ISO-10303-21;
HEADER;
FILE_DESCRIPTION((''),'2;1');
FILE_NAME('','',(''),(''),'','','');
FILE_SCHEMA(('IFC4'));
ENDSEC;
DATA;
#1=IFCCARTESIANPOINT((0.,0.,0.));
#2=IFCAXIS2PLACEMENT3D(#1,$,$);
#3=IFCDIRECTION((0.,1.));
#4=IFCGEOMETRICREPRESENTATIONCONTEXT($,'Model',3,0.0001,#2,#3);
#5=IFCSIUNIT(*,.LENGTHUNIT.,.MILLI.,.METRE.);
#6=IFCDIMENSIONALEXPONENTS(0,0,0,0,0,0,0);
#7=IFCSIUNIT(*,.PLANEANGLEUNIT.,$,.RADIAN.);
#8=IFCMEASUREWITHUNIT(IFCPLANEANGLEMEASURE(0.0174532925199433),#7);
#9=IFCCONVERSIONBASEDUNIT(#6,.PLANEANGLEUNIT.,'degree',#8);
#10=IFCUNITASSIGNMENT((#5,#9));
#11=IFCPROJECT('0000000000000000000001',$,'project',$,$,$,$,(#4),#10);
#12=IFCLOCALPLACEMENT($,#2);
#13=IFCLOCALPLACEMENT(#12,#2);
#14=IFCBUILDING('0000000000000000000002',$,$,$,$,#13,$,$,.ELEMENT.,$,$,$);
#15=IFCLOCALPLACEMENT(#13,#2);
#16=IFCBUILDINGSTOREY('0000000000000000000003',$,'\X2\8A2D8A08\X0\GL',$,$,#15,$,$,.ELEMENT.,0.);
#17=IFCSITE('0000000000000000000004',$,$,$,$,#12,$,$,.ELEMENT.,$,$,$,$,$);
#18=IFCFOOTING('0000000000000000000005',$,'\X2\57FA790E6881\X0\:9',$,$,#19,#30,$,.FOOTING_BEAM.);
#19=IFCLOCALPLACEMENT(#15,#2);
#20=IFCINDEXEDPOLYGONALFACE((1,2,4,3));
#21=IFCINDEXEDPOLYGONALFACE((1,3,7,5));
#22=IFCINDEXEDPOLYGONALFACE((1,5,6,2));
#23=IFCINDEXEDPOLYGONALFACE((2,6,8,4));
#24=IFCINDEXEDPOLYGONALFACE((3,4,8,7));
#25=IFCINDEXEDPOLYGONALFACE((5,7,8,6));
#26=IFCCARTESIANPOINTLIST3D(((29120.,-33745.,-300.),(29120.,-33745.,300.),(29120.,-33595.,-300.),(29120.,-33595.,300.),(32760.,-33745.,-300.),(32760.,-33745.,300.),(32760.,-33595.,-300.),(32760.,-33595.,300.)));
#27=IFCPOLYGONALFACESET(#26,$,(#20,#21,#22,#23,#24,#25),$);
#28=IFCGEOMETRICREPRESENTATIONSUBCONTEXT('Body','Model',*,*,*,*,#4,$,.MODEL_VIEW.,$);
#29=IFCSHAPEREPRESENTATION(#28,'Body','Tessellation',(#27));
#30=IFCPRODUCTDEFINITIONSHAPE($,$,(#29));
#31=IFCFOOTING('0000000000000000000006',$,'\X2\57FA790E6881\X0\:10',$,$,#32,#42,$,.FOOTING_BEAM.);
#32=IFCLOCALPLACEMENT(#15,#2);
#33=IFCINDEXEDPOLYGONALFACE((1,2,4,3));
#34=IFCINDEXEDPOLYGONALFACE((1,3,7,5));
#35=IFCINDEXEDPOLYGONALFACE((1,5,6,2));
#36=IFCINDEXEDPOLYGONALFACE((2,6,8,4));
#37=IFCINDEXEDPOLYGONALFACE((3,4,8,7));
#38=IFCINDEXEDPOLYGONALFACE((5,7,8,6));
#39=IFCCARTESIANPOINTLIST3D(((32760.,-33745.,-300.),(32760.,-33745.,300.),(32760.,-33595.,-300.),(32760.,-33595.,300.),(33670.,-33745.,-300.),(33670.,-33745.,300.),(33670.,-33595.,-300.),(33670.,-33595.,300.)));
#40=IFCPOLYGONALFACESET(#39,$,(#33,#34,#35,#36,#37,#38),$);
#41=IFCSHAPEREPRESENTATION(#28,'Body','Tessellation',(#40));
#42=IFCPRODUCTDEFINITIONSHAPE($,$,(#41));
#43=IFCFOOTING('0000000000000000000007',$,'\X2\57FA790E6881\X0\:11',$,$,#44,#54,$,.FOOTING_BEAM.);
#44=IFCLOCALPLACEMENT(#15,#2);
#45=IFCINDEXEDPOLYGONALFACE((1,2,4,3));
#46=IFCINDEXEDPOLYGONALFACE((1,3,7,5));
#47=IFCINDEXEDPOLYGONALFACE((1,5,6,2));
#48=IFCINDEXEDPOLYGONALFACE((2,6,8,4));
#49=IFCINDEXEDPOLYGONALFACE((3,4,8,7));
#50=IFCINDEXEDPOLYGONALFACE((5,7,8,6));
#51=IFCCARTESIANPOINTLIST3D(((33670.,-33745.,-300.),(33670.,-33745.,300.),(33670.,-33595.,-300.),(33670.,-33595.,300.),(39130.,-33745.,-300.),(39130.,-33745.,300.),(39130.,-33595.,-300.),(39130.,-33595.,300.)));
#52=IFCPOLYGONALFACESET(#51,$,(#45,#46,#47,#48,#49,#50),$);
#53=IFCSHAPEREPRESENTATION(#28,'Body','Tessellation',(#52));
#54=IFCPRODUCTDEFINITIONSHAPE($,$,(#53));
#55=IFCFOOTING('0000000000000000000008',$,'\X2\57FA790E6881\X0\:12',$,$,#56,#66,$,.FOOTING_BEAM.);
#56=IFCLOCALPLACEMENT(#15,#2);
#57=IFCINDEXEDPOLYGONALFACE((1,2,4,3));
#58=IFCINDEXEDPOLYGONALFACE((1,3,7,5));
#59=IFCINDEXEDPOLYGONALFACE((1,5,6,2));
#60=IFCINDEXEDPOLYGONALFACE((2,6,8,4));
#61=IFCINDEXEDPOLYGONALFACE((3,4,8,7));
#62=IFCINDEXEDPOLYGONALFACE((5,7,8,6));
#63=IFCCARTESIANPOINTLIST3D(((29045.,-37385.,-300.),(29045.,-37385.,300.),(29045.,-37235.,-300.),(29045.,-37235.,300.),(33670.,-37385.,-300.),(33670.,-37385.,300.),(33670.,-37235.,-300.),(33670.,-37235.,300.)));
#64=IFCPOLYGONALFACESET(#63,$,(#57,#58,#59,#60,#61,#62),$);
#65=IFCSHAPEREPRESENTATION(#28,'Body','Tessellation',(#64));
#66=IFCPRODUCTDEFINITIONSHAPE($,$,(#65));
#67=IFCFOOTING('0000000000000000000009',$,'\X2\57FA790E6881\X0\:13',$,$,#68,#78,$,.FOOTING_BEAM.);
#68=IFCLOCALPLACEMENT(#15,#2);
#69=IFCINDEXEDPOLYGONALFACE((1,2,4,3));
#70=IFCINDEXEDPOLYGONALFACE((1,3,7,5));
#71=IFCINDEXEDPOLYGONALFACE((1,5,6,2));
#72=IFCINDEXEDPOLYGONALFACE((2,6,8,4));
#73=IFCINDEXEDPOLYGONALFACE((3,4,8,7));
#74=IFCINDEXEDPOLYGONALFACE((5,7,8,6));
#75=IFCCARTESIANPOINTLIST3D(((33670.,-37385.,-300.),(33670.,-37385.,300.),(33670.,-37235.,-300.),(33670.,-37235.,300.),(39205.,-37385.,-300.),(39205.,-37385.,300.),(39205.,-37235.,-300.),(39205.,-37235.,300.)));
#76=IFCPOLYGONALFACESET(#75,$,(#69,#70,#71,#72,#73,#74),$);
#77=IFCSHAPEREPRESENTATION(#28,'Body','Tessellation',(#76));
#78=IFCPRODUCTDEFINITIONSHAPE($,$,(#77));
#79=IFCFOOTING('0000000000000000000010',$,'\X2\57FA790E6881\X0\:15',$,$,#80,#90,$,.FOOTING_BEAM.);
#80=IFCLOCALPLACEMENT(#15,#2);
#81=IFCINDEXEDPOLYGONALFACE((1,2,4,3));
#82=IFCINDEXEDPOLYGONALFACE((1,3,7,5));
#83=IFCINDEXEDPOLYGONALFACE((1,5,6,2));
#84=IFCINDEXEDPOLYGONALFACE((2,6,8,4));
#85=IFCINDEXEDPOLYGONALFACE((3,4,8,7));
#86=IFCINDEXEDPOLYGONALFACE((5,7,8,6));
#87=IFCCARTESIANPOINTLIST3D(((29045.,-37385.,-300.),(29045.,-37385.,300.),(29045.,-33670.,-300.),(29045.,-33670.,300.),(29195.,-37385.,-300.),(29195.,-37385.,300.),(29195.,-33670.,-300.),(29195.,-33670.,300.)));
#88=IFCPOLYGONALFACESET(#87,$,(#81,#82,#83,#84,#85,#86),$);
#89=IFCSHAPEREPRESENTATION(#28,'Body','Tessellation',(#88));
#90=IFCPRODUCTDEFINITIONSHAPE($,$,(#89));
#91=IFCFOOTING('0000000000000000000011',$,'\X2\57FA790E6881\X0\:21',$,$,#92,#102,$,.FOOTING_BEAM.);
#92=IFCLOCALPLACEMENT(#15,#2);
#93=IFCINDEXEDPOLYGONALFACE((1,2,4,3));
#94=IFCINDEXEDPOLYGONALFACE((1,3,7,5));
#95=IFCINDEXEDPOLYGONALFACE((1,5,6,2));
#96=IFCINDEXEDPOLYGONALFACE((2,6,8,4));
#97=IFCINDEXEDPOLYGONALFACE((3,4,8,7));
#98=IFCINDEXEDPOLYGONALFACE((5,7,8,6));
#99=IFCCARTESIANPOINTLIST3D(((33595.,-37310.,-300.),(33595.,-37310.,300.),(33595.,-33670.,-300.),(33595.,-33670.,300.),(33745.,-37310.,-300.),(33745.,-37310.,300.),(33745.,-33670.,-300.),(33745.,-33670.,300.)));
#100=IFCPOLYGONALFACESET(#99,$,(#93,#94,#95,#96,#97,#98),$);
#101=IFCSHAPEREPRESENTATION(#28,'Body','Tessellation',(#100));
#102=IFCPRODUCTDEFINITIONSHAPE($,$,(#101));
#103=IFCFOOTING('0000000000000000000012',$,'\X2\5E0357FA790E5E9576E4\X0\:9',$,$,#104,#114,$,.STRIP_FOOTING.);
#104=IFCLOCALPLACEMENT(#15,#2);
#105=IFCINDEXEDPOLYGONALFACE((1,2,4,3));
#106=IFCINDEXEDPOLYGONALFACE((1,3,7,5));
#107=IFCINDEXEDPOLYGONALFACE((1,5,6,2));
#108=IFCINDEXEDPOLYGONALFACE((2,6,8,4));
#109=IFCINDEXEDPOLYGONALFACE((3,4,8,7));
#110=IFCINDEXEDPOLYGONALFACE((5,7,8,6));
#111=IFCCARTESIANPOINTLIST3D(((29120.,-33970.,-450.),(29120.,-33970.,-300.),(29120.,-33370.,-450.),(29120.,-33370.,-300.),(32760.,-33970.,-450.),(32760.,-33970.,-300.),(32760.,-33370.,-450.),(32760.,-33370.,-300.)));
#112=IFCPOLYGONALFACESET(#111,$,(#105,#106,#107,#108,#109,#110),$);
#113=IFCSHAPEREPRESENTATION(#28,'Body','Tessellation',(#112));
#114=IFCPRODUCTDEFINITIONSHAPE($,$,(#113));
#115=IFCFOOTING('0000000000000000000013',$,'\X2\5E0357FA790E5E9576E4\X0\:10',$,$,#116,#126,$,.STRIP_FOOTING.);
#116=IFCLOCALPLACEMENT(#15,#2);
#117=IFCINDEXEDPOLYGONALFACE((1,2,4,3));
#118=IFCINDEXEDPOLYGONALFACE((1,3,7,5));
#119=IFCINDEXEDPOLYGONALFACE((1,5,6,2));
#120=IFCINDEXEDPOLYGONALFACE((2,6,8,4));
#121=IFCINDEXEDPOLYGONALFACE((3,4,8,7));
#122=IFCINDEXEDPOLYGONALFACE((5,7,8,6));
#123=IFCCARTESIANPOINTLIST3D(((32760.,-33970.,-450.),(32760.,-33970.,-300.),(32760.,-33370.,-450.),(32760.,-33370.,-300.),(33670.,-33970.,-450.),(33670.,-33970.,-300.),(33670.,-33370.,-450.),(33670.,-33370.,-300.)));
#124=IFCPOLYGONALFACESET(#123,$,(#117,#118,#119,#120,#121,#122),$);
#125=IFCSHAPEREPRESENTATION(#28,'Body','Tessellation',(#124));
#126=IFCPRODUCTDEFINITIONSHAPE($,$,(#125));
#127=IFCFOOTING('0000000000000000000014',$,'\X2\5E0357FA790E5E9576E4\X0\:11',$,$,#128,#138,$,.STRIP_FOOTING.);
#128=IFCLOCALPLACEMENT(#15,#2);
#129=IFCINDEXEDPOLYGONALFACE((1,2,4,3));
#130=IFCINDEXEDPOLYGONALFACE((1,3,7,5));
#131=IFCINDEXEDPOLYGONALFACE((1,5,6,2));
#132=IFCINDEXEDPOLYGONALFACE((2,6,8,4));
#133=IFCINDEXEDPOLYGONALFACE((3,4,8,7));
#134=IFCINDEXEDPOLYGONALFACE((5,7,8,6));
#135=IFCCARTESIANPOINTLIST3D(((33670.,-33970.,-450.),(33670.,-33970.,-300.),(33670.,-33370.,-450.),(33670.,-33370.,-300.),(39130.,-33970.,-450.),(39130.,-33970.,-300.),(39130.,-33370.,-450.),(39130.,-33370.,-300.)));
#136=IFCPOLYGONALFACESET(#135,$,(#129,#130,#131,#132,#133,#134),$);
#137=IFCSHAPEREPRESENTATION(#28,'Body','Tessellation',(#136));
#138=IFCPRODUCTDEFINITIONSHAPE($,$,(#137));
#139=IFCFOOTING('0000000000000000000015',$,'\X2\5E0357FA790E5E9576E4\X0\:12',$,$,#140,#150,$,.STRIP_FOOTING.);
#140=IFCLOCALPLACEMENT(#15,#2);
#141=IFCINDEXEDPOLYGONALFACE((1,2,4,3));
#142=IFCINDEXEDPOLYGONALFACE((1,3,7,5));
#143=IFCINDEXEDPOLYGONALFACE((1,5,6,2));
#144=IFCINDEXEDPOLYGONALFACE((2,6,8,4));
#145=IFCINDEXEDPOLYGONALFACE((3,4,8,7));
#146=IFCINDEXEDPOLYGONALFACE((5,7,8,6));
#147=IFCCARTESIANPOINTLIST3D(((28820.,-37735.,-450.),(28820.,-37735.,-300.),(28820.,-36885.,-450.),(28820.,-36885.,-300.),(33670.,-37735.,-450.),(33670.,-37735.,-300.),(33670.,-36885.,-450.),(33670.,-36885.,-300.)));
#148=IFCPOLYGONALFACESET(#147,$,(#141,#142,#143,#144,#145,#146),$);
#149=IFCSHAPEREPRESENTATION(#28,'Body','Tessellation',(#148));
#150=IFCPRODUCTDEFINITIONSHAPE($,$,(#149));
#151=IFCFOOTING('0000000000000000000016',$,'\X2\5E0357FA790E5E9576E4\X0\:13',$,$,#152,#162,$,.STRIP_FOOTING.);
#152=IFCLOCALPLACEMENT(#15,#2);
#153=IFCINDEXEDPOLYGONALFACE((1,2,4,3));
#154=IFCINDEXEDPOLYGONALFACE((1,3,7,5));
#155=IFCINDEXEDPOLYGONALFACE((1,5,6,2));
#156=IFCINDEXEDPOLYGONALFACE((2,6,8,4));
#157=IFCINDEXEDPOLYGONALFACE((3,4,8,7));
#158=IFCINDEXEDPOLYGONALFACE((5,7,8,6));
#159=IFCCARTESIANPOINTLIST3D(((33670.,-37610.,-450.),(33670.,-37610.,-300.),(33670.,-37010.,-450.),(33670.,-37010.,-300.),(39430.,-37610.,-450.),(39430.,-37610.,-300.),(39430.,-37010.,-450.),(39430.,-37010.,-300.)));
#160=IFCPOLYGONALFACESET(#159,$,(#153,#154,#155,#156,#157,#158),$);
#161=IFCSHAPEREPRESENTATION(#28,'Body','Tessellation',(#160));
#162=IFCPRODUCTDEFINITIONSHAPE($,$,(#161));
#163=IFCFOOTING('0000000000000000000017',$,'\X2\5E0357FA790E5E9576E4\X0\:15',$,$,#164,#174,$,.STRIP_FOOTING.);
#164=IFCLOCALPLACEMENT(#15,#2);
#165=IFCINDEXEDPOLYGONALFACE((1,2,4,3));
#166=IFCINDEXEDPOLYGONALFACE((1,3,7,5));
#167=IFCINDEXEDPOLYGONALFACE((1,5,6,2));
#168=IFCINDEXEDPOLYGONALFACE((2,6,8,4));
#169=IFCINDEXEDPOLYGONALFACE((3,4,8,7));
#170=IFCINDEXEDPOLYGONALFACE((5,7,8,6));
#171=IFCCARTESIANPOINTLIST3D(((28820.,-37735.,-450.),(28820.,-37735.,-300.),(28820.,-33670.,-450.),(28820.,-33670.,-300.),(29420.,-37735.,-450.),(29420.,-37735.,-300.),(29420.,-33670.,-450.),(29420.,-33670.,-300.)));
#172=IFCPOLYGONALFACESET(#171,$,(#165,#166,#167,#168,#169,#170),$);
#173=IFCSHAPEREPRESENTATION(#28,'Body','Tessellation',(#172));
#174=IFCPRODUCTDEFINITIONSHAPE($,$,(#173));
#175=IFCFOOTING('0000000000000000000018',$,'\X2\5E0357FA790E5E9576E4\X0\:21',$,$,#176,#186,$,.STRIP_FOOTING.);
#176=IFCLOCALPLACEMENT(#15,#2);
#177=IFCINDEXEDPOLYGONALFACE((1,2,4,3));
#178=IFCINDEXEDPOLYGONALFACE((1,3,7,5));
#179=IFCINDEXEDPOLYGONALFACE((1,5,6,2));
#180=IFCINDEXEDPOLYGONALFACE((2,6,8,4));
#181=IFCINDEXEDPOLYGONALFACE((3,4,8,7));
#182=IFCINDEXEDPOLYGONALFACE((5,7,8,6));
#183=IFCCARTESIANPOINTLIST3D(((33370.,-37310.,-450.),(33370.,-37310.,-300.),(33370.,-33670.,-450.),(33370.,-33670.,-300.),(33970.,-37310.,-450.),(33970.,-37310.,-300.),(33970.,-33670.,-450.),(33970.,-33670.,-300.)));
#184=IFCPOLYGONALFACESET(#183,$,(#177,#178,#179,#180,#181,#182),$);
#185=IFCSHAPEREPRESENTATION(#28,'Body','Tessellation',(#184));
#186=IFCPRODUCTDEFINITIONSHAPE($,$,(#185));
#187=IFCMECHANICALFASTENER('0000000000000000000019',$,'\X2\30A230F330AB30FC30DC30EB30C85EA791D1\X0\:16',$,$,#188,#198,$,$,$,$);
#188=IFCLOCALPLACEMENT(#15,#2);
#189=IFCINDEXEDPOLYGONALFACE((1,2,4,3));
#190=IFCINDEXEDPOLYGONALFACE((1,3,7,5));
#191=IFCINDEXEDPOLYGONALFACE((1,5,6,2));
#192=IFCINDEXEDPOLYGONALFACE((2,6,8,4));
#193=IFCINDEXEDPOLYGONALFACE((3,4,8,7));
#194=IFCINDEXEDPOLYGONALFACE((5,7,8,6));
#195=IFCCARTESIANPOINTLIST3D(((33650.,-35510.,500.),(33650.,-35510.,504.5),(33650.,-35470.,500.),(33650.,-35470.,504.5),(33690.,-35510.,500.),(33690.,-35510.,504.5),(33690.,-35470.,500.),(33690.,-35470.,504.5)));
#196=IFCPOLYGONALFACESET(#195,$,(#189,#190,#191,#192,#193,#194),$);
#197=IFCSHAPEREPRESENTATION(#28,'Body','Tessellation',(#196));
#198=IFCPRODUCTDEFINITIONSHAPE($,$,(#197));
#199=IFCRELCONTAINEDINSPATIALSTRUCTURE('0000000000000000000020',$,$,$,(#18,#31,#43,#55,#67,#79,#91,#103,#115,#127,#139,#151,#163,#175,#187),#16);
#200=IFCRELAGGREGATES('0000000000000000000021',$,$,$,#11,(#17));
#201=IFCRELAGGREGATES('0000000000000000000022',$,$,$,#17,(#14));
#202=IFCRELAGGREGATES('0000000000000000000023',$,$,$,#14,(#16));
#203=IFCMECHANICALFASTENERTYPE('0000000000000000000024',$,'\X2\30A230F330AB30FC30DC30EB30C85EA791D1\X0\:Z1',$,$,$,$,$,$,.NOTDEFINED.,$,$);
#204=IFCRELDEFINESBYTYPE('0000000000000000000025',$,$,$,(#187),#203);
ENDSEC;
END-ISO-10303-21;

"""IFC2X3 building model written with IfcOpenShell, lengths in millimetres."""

from ifc_helpers import new_model, entity, si_unit, converted_unit, direction, frame, origin, origin_with_axes, origin_2d, place, context, subcontext, project, spatial, rectangle, extrude, type_object, element, save


model = new_model("IFC2X3")

# Units and contexts
model_context = context("Model", 3, precision=0.0001, world=origin(), true_north=direction((0.0, 1.0)))
body_context = subcontext(model_context, "Body", "Model", "MODEL_VIEW")
ifc_project = project(units=[si_unit("LENGTHUNIT", "METRE", prefix="MILLI"), converted_unit("PLANEANGLEUNIT", "degree", entity("IfcPlaneAngleMeasure", 0.0174532925199433), si_unit("PLANEANGLEUNIT", "RADIAN"), dimensions=[0, 0, 0, 0, 0, 0, 0])], contexts=[model_context])

# Site, building, storey
site_placement = place(None, origin())
site = spatial("IfcSite", under=ifc_project, at=site_placement, CompositionType="ELEMENT")
building_placement = place(site_placement, origin())
building = spatial("IfcBuilding", under=site, at=building_placement, CompositionType="ELEMENT")
storey_placement = place(building_placement, origin())
storey = spatial("IfcBuildingStorey", under=building, at=storey_placement, Name="設計GL", CompositionType="ELEMENT", Elevation=0.0)

# Footings
footing_1_placement = place(storey_placement, frame((29120.0, -33670.0, 0.0), z_axis=(1.0, 0.0, 0.0), x_axis=(0.0, 1.0, 0.0)))
element("IfcFooting", 1, at=footing_1_placement, inside=storey, Name="基礎梁:9", PredefinedType="FOOTING_BEAM", context=body_context, shape_type="SolidModel", body=[
    extrude(rectangle(XDim=150.0, YDim=600.0, at=origin_2d()), origin_with_axes(), (0.0, 0.0, 1.0), 3640.0),
])
footing_2_placement = place(storey_placement, frame((32760.0, -33670.0, 0.0), z_axis=(1.0, 0.0, 0.0), x_axis=(0.0, 1.0, 0.0)))
element("IfcFooting", 2, at=footing_2_placement, inside=storey, Name="基礎梁:10", PredefinedType="FOOTING_BEAM", context=body_context, shape_type="SolidModel", body=[
    extrude(rectangle(XDim=150.0, YDim=600.0, at=origin_2d()), origin_with_axes(), (0.0, 0.0, 1.0), 910.0),
])
footing_3_placement = place(storey_placement, frame((33670.0, -33670.0, 0.0), z_axis=(1.0, 0.0, 0.0), x_axis=(0.0, 1.0, 0.0)))
element("IfcFooting", 3, at=footing_3_placement, inside=storey, Name="基礎梁:11", PredefinedType="FOOTING_BEAM", context=body_context, shape_type="SolidModel", body=[
    extrude(rectangle(XDim=150.0, YDim=600.0, at=origin_2d()), origin_with_axes(), (0.0, 0.0, 1.0), 5460.0),
])
footing_4_placement = place(storey_placement, frame((29045.0, -37310.0, 0.0), z_axis=(1.0, 0.0, 0.0), x_axis=(0.0, 1.0, 0.0)))
element("IfcFooting", 4, at=footing_4_placement, inside=storey, Name="基礎梁:12", PredefinedType="FOOTING_BEAM", context=body_context, shape_type="SolidModel", body=[
    extrude(rectangle(XDim=150.0, YDim=600.0, at=origin_2d()), origin_with_axes(), (0.0, 0.0, 1.0), 4625.0),
])
footing_5_placement = place(storey_placement, frame((33670.0, -37310.0, 0.0), z_axis=(1.0, 0.0, 0.0), x_axis=(0.0, 1.0, 0.0)))
element("IfcFooting", 5, at=footing_5_placement, inside=storey, Name="基礎梁:13", PredefinedType="FOOTING_BEAM", context=body_context, shape_type="SolidModel", body=[
    extrude(rectangle(XDim=150.0, YDim=600.0, at=origin_2d()), origin_with_axes(), (0.0, 0.0, 1.0), 5535.0),
])
footing_6_placement = place(storey_placement, frame((29120.0, -33670.0, 0.0), z_axis=(0.0, -1.0, 0.0), x_axis=(1.0, 0.0, 0.0)))
element("IfcFooting", 6, at=footing_6_placement, inside=storey, Name="基礎梁:15", PredefinedType="FOOTING_BEAM", context=body_context, shape_type="SolidModel", body=[
    extrude(rectangle(XDim=150.0, YDim=600.0, at=origin_2d()), origin_with_axes(), (0.0, 0.0, 1.0), 3715.0),
])
footing_7_placement = place(storey_placement, frame((33670.0, -33670.0, 0.0), z_axis=(0.0, -1.0, 0.0), x_axis=(1.0, 0.0, 0.0)))
element("IfcFooting", 7, at=footing_7_placement, inside=storey, Name="基礎梁:21", PredefinedType="FOOTING_BEAM", context=body_context, shape_type="SolidModel", body=[
    extrude(rectangle(XDim=150.0, YDim=600.0, at=origin_2d()), origin_with_axes(), (0.0, 0.0, 1.0), 3640.0),
])
footing_8_placement = place(storey_placement, frame((29120.0, -33670.0, -375.0), z_axis=(1.0, 0.0, 0.0), x_axis=(0.0, -1.0, 0.0)))
element("IfcFooting", 8, at=footing_8_placement, inside=storey, Name="布基礎底盤:9", PredefinedType="STRIP_FOOTING", context=body_context, shape_type="SweptSolid", body=[
    extrude(rectangle(XDim=600.0, YDim=150.0, at=origin_2d()), origin_with_axes(), (0.0, 0.0, 1.0), 3640.0),
])
footing_9_placement = place(storey_placement, frame((32760.0, -33670.0, -375.0), z_axis=(1.0, 0.0, 0.0), x_axis=(0.0, -1.0, 0.0)))
element("IfcFooting", 9, at=footing_9_placement, inside=storey, Name="布基礎底盤:10", PredefinedType="STRIP_FOOTING", context=body_context, shape_type="SweptSolid", body=[
    extrude(rectangle(XDim=600.0, YDim=150.0, at=origin_2d()), origin_with_axes(), (0.0, 0.0, 1.0), 910.0),
])
footing_10_placement = place(storey_placement, frame((33670.0, -33670.0, -375.0), z_axis=(1.0, 0.0, 0.0), x_axis=(0.0, -1.0, 0.0)))
element("IfcFooting", 10, at=footing_10_placement, inside=storey, Name="布基礎底盤:11", PredefinedType="STRIP_FOOTING", context=body_context, shape_type="SweptSolid", body=[
    extrude(rectangle(XDim=600.0, YDim=150.0, at=origin_2d()), origin_with_axes(), (0.0, 0.0, 1.0), 5460.0),
])
footing_11_placement = place(storey_placement, frame((28820.0, -37310.0, -375.0), z_axis=(1.0, 0.0, 0.0), x_axis=(0.0, -1.0, 0.0)))
element("IfcFooting", 11, at=footing_11_placement, inside=storey, Name="布基礎底盤:12", PredefinedType="STRIP_FOOTING", context=body_context, shape_type="SweptSolid", body=[
    extrude(rectangle(XDim=850.0, YDim=150.0, at=origin_2d()), origin_with_axes(), (0.0, 0.0, 1.0), 4850.0),
])
footing_12_placement = place(storey_placement, frame((33670.0, -37310.0, -375.0), z_axis=(1.0, 0.0, 0.0), x_axis=(0.0, -1.0, 0.0)))
element("IfcFooting", 12, at=footing_12_placement, inside=storey, Name="布基礎底盤:13", PredefinedType="STRIP_FOOTING", context=body_context, shape_type="SweptSolid", body=[
    extrude(rectangle(XDim=600.0, YDim=150.0, at=origin_2d()), origin_with_axes(), (0.0, 0.0, 1.0), 5760.0),
])
footing_13_placement = place(storey_placement, frame((29120.0, -33670.0, -375.0), z_axis=(0.0, -1.0, 0.0), x_axis=(-1.0, 0.0, 0.0)))
element("IfcFooting", 13, at=footing_13_placement, inside=storey, Name="布基礎底盤:15", PredefinedType="STRIP_FOOTING", context=body_context, shape_type="SweptSolid", body=[
    extrude(rectangle(XDim=600.0, YDim=150.0, at=origin_2d()), origin_with_axes(), (0.0, 0.0, 1.0), 4065.0),
])
footing_14_placement = place(storey_placement, frame((33670.0, -33670.0, -375.0), z_axis=(0.0, -1.0, 0.0), x_axis=(-1.0, 0.0, 0.0)))
element("IfcFooting", 14, at=footing_14_placement, inside=storey, Name="布基礎底盤:21", PredefinedType="STRIP_FOOTING", context=body_context, shape_type="SweptSolid", body=[
    extrude(rectangle(XDim=600.0, YDim=150.0, at=origin_2d()), origin_with_axes(), (0.0, 0.0, 1.0), 3640.0),
])

# Mechanical fastener
mechanical_fastener_type_1 = type_object("IfcMechanicalFastenerType", Name="アンカーボルト座金:Z1")
mechanical_fastener_1_placement = place(storey_placement, frame((33670.0, -35490.0, 500.0)))
element("IfcMechanicalFastener", 15, at=mechanical_fastener_1_placement, inside=storey, type_object=mechanical_fastener_type_1, Name="アンカーボルト座金:16", context=body_context, shape_type="SweptSolid", body=[
    extrude(rectangle(XDim=40.0, YDim=40.0, at=origin_2d()), origin_with_axes(), (0.0, 0.0, 1.0), 4.5),
])

save(model, "model.ifc")
